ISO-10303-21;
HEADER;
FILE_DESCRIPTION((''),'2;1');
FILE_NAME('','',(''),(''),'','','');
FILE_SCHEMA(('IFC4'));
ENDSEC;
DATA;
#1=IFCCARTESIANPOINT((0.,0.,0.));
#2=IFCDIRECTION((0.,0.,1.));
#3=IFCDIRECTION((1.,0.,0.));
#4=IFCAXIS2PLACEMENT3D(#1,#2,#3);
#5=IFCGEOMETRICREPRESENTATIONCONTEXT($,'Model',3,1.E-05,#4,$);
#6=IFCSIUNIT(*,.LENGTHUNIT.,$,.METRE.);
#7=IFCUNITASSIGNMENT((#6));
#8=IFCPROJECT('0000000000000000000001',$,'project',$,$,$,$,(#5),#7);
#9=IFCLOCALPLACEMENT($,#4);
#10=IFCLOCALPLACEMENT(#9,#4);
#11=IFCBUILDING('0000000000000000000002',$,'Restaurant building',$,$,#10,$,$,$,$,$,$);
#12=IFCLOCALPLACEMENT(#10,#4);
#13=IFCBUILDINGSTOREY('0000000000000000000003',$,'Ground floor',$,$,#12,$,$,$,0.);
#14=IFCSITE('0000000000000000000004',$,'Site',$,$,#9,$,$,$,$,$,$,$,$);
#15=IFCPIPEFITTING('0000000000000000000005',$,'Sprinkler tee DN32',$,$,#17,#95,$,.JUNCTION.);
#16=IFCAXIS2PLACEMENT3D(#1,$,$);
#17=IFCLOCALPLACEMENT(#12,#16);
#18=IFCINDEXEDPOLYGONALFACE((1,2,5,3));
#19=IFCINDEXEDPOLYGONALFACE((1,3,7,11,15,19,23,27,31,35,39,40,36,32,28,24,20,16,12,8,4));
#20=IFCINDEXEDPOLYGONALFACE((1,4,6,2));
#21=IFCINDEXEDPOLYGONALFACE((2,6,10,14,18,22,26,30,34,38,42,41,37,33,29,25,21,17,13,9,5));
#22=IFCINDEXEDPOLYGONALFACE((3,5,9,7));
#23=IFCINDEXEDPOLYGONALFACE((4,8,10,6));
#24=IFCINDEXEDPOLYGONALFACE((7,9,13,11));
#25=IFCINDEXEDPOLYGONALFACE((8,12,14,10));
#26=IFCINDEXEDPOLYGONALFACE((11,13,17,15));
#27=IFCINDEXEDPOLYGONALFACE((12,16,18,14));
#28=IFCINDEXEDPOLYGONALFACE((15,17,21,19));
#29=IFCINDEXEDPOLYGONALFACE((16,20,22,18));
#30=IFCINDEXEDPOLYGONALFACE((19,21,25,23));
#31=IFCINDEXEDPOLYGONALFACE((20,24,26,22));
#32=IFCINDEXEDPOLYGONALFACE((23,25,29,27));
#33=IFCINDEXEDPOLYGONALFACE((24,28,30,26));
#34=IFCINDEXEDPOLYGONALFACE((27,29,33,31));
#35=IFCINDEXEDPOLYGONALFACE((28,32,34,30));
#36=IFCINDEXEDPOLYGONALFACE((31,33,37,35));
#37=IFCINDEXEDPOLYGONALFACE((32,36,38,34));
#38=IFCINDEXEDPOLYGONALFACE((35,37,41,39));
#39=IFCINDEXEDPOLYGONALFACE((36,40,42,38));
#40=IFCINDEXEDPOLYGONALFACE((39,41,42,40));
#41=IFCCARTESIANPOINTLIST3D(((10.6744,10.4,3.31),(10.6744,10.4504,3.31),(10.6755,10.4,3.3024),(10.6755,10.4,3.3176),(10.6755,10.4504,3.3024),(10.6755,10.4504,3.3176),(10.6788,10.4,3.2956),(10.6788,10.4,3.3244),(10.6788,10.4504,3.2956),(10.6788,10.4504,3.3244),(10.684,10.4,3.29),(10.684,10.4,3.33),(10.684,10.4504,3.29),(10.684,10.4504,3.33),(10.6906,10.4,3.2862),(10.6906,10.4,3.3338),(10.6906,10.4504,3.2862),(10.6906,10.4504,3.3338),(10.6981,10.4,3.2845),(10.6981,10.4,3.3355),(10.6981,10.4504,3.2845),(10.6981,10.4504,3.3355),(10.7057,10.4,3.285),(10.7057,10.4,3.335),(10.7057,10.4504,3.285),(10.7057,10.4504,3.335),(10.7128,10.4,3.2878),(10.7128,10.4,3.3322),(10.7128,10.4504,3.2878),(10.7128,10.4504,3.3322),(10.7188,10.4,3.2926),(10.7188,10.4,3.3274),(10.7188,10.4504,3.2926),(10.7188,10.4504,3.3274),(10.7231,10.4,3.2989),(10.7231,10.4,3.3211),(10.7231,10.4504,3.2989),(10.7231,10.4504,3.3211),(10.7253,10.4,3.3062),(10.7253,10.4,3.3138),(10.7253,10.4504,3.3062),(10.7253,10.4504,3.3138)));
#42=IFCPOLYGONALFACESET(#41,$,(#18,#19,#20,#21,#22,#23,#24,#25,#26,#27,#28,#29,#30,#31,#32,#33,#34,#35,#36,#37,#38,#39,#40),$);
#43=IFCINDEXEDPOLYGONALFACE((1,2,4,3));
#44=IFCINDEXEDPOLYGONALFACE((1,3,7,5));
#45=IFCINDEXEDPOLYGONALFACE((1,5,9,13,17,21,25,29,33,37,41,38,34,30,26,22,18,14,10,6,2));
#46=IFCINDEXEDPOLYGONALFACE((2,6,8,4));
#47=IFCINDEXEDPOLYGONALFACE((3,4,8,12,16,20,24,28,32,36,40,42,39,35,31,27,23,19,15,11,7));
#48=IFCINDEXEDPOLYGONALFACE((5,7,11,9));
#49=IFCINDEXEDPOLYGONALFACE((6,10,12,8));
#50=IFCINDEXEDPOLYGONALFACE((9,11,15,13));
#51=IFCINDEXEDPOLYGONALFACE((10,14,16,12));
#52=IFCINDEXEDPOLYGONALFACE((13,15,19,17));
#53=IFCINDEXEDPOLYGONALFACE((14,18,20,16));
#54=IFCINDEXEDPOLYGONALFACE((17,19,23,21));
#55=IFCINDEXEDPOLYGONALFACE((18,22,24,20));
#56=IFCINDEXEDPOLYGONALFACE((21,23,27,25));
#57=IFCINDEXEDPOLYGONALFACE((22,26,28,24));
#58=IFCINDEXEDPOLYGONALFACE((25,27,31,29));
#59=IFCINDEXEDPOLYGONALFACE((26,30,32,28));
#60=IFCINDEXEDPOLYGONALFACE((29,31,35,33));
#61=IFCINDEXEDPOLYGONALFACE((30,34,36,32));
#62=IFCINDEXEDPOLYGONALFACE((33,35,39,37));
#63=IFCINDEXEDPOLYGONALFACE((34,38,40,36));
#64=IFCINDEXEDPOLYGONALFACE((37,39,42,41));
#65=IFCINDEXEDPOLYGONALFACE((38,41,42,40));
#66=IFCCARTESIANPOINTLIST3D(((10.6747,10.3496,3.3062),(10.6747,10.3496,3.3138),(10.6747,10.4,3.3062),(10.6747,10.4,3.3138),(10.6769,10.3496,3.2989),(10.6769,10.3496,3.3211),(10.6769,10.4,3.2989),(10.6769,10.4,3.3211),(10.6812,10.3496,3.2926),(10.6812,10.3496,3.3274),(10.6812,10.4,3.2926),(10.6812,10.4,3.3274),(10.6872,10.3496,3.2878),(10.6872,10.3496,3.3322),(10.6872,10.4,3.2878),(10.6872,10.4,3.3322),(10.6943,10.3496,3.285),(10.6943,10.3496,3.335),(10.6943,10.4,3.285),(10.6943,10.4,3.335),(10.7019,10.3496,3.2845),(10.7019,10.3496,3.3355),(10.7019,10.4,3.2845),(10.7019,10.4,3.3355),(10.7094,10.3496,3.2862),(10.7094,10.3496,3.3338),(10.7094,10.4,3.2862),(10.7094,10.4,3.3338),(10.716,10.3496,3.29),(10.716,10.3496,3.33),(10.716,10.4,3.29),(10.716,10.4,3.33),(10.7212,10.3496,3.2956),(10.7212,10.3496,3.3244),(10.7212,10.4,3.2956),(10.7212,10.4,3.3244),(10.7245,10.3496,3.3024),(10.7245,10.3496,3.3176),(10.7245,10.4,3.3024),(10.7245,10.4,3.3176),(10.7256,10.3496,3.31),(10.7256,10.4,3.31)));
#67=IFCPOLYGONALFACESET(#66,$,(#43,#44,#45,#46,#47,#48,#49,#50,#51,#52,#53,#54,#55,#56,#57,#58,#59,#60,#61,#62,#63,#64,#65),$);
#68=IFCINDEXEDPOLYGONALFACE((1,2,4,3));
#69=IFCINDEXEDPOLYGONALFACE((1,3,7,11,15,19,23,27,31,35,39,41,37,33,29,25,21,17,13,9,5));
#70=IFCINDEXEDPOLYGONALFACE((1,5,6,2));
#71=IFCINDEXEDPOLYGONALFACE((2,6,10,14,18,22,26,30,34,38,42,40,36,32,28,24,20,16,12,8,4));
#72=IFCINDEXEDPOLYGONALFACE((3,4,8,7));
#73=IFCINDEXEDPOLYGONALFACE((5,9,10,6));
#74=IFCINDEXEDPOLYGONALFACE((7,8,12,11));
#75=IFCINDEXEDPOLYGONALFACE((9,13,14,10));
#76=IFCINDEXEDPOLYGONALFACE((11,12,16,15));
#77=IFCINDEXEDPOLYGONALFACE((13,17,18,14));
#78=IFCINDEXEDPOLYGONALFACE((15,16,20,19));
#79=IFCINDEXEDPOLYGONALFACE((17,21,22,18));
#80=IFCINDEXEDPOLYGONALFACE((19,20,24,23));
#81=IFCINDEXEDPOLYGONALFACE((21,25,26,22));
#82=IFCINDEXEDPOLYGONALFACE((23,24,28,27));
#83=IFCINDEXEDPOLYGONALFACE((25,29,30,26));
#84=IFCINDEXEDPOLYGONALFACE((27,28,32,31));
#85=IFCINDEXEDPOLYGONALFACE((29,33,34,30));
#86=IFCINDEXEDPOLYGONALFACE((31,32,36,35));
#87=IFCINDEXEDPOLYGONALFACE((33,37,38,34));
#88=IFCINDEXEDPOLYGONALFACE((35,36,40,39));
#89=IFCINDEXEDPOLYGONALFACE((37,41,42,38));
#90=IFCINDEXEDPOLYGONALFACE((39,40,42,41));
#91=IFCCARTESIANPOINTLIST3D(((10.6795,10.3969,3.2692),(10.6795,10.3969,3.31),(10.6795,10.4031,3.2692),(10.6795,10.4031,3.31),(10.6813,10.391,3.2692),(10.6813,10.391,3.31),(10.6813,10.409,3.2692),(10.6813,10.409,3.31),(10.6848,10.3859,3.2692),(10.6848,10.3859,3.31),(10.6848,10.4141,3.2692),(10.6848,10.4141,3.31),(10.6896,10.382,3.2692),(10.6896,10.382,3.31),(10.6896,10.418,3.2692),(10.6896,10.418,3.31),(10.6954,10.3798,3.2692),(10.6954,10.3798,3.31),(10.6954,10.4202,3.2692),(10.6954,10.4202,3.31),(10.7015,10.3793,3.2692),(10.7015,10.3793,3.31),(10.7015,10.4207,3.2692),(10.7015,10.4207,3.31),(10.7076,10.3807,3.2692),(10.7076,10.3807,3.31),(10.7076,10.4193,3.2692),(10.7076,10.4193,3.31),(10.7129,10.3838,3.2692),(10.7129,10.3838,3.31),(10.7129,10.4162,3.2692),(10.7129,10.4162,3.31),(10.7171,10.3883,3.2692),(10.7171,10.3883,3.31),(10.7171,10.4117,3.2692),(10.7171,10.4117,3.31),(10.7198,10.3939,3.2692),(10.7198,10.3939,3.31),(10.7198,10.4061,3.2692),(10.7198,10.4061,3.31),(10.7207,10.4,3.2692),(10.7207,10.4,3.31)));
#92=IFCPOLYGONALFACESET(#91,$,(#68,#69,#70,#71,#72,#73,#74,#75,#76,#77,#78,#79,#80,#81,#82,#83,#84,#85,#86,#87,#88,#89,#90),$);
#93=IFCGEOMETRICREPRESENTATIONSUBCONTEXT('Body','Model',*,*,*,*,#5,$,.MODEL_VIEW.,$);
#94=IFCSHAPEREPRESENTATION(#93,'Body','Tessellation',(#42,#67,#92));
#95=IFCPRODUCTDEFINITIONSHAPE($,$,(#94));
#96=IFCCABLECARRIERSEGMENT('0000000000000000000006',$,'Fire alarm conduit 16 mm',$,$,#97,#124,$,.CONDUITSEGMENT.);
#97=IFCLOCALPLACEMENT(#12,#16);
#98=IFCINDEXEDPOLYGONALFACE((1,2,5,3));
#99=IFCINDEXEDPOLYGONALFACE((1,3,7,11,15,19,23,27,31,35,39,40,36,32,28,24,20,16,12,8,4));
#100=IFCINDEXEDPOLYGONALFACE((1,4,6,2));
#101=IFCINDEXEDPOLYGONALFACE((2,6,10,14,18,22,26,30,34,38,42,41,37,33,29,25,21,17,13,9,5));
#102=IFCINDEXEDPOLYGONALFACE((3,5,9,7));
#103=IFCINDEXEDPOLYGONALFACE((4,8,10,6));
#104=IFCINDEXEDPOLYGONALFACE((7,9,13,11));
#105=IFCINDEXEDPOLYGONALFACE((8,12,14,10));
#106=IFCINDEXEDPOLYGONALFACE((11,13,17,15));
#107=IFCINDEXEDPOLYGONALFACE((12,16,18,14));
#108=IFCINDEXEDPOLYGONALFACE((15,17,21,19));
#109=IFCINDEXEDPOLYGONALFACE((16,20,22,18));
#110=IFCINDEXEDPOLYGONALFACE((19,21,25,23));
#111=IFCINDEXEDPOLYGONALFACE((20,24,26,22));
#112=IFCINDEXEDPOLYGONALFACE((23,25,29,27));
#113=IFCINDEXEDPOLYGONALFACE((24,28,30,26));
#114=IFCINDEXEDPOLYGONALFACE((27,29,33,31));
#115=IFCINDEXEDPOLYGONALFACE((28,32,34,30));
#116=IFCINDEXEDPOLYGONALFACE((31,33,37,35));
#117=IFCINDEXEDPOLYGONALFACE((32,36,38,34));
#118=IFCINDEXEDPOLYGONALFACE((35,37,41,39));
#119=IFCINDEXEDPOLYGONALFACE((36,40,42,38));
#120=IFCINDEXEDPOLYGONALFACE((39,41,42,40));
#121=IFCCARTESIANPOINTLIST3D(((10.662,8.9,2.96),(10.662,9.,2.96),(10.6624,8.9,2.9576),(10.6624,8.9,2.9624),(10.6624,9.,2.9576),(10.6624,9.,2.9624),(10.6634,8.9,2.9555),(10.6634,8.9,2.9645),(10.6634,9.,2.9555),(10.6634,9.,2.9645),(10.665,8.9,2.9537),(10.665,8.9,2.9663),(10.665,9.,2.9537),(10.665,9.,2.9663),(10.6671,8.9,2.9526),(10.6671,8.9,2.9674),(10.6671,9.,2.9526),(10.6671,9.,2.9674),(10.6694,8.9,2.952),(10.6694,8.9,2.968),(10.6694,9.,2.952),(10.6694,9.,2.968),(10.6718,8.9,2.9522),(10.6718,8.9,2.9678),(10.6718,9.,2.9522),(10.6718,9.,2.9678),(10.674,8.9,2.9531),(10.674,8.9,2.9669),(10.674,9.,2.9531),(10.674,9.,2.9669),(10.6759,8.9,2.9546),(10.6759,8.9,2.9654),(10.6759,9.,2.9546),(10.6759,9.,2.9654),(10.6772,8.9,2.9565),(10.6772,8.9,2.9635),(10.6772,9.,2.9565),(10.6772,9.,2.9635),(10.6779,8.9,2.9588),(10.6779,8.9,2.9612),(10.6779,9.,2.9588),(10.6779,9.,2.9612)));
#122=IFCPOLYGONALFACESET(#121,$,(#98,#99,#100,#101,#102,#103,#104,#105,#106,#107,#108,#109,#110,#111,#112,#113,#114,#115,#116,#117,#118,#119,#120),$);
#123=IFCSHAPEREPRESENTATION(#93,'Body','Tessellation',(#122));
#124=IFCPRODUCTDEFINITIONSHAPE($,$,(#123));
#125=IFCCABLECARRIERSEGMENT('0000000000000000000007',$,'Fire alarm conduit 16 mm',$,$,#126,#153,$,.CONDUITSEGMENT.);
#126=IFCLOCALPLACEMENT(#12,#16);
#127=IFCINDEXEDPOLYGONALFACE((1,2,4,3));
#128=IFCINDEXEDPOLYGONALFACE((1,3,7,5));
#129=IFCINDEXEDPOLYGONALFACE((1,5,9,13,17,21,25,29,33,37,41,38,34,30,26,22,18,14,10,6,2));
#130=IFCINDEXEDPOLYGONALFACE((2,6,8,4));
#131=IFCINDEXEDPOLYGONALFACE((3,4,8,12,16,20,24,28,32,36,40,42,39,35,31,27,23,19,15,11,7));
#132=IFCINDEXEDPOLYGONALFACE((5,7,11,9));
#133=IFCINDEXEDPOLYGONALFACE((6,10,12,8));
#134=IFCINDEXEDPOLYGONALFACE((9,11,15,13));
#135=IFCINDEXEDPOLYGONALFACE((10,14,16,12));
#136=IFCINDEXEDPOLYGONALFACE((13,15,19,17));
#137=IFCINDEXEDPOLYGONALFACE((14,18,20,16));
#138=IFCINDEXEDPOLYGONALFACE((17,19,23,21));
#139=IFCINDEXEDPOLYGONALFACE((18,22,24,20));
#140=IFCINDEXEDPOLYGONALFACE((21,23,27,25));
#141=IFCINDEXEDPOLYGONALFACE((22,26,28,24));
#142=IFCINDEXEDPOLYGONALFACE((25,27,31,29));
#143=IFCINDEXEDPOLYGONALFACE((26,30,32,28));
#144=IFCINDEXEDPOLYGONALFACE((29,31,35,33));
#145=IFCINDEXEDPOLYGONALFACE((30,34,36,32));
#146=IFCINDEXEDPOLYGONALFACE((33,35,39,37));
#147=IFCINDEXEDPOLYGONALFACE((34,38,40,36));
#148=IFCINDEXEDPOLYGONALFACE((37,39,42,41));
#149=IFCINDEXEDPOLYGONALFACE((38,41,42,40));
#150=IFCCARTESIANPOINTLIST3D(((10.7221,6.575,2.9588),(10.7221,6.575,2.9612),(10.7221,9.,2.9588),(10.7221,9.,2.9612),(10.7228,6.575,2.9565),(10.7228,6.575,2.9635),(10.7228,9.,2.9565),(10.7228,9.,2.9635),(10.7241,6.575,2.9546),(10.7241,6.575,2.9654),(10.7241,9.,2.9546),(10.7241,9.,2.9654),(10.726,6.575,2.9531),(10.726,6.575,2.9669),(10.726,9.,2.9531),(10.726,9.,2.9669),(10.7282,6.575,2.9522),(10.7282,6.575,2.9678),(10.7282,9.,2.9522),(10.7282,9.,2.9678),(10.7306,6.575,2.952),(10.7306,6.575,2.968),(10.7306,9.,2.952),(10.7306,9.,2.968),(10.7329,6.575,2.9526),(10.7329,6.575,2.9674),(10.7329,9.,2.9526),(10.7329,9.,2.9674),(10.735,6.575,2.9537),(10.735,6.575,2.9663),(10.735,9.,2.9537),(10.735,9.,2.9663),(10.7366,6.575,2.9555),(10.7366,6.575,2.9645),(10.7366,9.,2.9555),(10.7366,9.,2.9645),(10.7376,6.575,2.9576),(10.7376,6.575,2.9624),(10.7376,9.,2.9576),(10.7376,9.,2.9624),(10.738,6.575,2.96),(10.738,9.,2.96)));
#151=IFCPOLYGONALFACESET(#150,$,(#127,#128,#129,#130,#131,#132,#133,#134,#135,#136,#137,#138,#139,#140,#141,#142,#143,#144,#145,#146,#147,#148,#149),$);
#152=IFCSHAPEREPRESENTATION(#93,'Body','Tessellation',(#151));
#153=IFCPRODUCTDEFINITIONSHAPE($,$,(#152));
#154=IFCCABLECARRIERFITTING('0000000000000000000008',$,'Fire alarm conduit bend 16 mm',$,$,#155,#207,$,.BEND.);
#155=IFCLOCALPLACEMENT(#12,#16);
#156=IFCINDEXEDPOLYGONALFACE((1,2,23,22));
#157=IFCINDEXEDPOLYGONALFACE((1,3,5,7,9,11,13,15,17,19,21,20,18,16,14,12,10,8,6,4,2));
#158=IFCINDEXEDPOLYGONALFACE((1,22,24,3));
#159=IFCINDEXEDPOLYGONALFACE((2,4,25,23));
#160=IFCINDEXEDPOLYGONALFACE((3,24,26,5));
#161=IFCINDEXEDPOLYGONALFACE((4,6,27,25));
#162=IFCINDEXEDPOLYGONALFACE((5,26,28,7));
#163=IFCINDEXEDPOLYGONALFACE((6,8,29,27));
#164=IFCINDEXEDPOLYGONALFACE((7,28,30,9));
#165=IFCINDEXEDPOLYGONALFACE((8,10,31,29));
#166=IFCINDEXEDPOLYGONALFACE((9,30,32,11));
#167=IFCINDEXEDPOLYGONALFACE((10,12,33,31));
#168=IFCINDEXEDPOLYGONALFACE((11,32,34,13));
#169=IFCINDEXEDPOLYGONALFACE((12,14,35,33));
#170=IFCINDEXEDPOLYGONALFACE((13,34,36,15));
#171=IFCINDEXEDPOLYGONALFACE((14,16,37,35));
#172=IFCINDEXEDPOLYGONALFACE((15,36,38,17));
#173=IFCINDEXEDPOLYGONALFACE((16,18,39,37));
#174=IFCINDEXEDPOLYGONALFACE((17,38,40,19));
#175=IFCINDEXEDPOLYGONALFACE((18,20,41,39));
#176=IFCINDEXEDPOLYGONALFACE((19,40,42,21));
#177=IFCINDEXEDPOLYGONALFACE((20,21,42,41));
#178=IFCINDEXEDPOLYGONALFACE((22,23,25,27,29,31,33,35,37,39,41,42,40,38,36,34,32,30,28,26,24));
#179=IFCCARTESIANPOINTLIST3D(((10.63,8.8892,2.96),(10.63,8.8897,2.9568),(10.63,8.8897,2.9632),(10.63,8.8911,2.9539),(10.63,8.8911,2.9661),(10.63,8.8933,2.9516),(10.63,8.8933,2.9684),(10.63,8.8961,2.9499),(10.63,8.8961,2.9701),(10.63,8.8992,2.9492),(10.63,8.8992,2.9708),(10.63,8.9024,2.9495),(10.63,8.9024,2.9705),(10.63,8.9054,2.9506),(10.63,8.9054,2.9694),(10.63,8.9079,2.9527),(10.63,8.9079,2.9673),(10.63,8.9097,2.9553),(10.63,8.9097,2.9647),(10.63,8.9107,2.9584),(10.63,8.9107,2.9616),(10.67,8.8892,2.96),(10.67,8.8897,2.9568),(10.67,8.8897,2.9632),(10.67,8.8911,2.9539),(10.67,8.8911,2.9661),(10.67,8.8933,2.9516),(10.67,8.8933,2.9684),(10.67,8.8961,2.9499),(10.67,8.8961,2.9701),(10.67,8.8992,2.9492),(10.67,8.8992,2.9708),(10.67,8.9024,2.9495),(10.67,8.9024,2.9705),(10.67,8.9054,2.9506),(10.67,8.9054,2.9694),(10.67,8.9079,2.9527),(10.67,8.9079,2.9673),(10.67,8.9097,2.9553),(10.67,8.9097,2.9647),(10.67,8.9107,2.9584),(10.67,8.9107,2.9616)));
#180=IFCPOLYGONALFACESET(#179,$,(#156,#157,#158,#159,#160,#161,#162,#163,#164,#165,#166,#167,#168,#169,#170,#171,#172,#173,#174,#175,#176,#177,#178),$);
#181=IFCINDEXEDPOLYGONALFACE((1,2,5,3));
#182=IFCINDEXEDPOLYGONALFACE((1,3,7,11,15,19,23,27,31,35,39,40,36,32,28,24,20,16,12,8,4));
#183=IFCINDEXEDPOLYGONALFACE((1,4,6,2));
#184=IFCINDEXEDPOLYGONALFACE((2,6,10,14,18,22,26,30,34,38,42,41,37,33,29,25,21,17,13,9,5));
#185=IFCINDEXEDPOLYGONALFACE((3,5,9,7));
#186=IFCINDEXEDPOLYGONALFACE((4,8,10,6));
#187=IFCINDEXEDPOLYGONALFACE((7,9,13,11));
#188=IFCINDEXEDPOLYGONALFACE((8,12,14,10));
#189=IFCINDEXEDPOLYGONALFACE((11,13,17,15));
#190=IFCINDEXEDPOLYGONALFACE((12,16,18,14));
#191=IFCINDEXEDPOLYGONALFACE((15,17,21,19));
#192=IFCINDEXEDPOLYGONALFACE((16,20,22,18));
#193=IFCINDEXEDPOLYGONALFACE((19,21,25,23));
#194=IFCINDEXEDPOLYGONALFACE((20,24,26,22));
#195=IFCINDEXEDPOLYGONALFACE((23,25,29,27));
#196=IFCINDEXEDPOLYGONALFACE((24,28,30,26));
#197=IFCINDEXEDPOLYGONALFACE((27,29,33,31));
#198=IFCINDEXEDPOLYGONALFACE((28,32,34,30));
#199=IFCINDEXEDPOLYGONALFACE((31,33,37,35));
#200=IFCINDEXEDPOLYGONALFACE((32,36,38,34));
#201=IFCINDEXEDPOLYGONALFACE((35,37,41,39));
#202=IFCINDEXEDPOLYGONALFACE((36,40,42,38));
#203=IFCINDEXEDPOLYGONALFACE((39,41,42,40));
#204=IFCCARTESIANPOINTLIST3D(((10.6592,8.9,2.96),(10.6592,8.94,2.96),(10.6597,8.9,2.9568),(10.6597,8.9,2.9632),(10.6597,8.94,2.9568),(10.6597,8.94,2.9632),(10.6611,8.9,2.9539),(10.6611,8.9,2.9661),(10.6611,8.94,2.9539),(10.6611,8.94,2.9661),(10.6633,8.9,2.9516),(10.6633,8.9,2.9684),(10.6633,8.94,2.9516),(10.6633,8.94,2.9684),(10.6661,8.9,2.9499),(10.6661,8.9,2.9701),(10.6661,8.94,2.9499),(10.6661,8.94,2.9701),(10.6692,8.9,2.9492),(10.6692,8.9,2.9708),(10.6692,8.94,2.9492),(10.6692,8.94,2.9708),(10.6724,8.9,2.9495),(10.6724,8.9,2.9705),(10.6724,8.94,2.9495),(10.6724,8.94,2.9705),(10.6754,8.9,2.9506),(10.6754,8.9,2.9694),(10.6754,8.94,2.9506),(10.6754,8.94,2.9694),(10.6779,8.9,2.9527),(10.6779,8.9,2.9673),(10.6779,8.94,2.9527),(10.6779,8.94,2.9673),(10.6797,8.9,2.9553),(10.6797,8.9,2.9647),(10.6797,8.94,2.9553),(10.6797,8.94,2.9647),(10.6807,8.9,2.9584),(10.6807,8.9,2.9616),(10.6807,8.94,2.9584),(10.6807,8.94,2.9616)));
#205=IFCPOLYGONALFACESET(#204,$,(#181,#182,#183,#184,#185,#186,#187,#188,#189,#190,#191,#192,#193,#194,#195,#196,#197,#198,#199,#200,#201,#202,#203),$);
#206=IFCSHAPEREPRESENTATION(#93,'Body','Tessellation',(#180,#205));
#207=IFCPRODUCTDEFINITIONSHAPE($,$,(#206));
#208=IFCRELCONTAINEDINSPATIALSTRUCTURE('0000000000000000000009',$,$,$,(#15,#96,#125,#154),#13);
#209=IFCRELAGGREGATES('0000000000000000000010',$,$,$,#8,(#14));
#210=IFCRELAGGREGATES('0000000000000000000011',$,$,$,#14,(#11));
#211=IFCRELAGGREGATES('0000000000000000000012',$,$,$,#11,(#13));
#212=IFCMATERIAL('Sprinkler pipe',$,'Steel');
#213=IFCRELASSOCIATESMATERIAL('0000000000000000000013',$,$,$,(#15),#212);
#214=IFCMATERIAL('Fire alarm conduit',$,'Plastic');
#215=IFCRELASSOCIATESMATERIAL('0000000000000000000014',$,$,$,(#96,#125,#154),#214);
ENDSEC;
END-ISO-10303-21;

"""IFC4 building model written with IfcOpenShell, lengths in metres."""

from ifc_helpers import new_model, si_unit, frame, origin_with_axes, origin_2d, place, context, subcontext, project, spatial, circle, extrude, material, element, save


model = new_model("IFC4")

# Units and contexts
model_context = context("Model", 3, precision=1e-05, world=origin_with_axes())
body_context = subcontext(model_context, "Body", "Model", "MODEL_VIEW")
ifc_project = project(units=[si_unit("LENGTHUNIT", "METRE")], contexts=[model_context])

# Site, building, storey
site_placement = place(None, origin_with_axes())
site = spatial("IfcSite", under=ifc_project, at=site_placement, Name="Site")
building_placement = place(site_placement, origin_with_axes())
building = spatial("IfcBuilding", under=site, at=building_placement, Name="Restaurant building")
storey_placement = place(building_placement, origin_with_axes())
storey = spatial("IfcBuildingStorey", under=building, at=storey_placement, Name="Ground floor", Elevation=0.0)

# Shared definitions
ifc_material_1 = material(Name="Sprinkler pipe", Category="Steel")

# Pipe fitting
pipe_fitting_1_placement = place(storey_placement, frame((10.7, 10.4, 3.31)))
element("IfcPipeFitting", 1, at=pipe_fitting_1_placement, inside=storey, material=ifc_material_1, Name="Sprinkler tee DN32", PredefinedType="JUNCTION", context=body_context, shape_type="SweptSolid", body=[
    extrude(circle(Radius=0.0256, at=origin_2d()), frame((0.0, 0.0, 0.0), z_axis=(0.0, 1.0, 0.0), x_axis=(-1.0, 0.0, 0.0)), (0.0, 0.0, 1.0), 0.0504),
    extrude(circle(Radius=0.0256, at=origin_2d()), frame((0.0, 0.0, 0.0), z_axis=(0.0, -1.0, 0.0), x_axis=(1.0, 0.0, 0.0)), (0.0, 0.0, 1.0), 0.0504),
    extrude(circle(Radius=0.0207, at=origin_2d()), frame((0.0, 0.0, 0.0), z_axis=(0.0, 0.0, -1.0), x_axis=(1.0, 0.0, 0.0)), (0.0, 0.0, 1.0), 0.0408),
])

# Cable carrier segments
ifc_material_2 = material(Name="Fire alarm conduit", Category="Plastic")
cable_carrier_segment_1_placement = place(storey_placement, frame((10.67, 8.9, 2.96)))
element("IfcCableCarrierSegment", 2, at=cable_carrier_segment_1_placement, inside=storey, material=ifc_material_2, Name="Fire alarm conduit 16 mm", PredefinedType="CONDUITSEGMENT", context=body_context, shape_type="SweptSolid", body=[
    extrude(circle(Radius=0.008, at=origin_2d()), frame((0.0, 0.0, 0.0), z_axis=(0.0, 1.0, 0.0), x_axis=(-1.0, 0.0, 0.0)), (0.0, 0.0, 1.0), 0.1),
])
cable_carrier_segment_2_placement = place(storey_placement, frame((10.73, 9.0, 2.96)))
element("IfcCableCarrierSegment", 3, at=cable_carrier_segment_2_placement, inside=storey, material=ifc_material_2, Name="Fire alarm conduit 16 mm", PredefinedType="CONDUITSEGMENT", context=body_context, shape_type="SweptSolid", body=[
    extrude(circle(Radius=0.008, at=origin_2d()), frame((0.0, 0.0, 0.0), z_axis=(0.0, -1.0, 0.0), x_axis=(1.0, 0.0, 0.0)), (0.0, 0.0, 1.0), 2.425),
])

# Cable carrier fitting
cable_carrier_fitting_1_placement = place(storey_placement, frame((10.67, 8.9, 2.96)))
element("IfcCableCarrierFitting", 4, at=cable_carrier_fitting_1_placement, inside=storey, material=ifc_material_2, Name="Fire alarm conduit bend 16 mm", PredefinedType="BEND", context=body_context, shape_type="SweptSolid", body=[
    extrude(circle(Radius=0.0108, at=origin_2d()), frame((0.0, 0.0, 0.0), z_axis=(-1.0, 0.0, 0.0), x_axis=(0.0, -1.0, 0.0)), (0.0, 0.0, 1.0), 0.04),
    extrude(circle(Radius=0.0108, at=origin_2d()), frame((0.0, 0.0, 0.0), z_axis=(0.0, 1.0, 0.0), x_axis=(-1.0, 0.0, 0.0)), (0.0, 0.0, 1.0), 0.04),
])

save(model, "model.ifc")
